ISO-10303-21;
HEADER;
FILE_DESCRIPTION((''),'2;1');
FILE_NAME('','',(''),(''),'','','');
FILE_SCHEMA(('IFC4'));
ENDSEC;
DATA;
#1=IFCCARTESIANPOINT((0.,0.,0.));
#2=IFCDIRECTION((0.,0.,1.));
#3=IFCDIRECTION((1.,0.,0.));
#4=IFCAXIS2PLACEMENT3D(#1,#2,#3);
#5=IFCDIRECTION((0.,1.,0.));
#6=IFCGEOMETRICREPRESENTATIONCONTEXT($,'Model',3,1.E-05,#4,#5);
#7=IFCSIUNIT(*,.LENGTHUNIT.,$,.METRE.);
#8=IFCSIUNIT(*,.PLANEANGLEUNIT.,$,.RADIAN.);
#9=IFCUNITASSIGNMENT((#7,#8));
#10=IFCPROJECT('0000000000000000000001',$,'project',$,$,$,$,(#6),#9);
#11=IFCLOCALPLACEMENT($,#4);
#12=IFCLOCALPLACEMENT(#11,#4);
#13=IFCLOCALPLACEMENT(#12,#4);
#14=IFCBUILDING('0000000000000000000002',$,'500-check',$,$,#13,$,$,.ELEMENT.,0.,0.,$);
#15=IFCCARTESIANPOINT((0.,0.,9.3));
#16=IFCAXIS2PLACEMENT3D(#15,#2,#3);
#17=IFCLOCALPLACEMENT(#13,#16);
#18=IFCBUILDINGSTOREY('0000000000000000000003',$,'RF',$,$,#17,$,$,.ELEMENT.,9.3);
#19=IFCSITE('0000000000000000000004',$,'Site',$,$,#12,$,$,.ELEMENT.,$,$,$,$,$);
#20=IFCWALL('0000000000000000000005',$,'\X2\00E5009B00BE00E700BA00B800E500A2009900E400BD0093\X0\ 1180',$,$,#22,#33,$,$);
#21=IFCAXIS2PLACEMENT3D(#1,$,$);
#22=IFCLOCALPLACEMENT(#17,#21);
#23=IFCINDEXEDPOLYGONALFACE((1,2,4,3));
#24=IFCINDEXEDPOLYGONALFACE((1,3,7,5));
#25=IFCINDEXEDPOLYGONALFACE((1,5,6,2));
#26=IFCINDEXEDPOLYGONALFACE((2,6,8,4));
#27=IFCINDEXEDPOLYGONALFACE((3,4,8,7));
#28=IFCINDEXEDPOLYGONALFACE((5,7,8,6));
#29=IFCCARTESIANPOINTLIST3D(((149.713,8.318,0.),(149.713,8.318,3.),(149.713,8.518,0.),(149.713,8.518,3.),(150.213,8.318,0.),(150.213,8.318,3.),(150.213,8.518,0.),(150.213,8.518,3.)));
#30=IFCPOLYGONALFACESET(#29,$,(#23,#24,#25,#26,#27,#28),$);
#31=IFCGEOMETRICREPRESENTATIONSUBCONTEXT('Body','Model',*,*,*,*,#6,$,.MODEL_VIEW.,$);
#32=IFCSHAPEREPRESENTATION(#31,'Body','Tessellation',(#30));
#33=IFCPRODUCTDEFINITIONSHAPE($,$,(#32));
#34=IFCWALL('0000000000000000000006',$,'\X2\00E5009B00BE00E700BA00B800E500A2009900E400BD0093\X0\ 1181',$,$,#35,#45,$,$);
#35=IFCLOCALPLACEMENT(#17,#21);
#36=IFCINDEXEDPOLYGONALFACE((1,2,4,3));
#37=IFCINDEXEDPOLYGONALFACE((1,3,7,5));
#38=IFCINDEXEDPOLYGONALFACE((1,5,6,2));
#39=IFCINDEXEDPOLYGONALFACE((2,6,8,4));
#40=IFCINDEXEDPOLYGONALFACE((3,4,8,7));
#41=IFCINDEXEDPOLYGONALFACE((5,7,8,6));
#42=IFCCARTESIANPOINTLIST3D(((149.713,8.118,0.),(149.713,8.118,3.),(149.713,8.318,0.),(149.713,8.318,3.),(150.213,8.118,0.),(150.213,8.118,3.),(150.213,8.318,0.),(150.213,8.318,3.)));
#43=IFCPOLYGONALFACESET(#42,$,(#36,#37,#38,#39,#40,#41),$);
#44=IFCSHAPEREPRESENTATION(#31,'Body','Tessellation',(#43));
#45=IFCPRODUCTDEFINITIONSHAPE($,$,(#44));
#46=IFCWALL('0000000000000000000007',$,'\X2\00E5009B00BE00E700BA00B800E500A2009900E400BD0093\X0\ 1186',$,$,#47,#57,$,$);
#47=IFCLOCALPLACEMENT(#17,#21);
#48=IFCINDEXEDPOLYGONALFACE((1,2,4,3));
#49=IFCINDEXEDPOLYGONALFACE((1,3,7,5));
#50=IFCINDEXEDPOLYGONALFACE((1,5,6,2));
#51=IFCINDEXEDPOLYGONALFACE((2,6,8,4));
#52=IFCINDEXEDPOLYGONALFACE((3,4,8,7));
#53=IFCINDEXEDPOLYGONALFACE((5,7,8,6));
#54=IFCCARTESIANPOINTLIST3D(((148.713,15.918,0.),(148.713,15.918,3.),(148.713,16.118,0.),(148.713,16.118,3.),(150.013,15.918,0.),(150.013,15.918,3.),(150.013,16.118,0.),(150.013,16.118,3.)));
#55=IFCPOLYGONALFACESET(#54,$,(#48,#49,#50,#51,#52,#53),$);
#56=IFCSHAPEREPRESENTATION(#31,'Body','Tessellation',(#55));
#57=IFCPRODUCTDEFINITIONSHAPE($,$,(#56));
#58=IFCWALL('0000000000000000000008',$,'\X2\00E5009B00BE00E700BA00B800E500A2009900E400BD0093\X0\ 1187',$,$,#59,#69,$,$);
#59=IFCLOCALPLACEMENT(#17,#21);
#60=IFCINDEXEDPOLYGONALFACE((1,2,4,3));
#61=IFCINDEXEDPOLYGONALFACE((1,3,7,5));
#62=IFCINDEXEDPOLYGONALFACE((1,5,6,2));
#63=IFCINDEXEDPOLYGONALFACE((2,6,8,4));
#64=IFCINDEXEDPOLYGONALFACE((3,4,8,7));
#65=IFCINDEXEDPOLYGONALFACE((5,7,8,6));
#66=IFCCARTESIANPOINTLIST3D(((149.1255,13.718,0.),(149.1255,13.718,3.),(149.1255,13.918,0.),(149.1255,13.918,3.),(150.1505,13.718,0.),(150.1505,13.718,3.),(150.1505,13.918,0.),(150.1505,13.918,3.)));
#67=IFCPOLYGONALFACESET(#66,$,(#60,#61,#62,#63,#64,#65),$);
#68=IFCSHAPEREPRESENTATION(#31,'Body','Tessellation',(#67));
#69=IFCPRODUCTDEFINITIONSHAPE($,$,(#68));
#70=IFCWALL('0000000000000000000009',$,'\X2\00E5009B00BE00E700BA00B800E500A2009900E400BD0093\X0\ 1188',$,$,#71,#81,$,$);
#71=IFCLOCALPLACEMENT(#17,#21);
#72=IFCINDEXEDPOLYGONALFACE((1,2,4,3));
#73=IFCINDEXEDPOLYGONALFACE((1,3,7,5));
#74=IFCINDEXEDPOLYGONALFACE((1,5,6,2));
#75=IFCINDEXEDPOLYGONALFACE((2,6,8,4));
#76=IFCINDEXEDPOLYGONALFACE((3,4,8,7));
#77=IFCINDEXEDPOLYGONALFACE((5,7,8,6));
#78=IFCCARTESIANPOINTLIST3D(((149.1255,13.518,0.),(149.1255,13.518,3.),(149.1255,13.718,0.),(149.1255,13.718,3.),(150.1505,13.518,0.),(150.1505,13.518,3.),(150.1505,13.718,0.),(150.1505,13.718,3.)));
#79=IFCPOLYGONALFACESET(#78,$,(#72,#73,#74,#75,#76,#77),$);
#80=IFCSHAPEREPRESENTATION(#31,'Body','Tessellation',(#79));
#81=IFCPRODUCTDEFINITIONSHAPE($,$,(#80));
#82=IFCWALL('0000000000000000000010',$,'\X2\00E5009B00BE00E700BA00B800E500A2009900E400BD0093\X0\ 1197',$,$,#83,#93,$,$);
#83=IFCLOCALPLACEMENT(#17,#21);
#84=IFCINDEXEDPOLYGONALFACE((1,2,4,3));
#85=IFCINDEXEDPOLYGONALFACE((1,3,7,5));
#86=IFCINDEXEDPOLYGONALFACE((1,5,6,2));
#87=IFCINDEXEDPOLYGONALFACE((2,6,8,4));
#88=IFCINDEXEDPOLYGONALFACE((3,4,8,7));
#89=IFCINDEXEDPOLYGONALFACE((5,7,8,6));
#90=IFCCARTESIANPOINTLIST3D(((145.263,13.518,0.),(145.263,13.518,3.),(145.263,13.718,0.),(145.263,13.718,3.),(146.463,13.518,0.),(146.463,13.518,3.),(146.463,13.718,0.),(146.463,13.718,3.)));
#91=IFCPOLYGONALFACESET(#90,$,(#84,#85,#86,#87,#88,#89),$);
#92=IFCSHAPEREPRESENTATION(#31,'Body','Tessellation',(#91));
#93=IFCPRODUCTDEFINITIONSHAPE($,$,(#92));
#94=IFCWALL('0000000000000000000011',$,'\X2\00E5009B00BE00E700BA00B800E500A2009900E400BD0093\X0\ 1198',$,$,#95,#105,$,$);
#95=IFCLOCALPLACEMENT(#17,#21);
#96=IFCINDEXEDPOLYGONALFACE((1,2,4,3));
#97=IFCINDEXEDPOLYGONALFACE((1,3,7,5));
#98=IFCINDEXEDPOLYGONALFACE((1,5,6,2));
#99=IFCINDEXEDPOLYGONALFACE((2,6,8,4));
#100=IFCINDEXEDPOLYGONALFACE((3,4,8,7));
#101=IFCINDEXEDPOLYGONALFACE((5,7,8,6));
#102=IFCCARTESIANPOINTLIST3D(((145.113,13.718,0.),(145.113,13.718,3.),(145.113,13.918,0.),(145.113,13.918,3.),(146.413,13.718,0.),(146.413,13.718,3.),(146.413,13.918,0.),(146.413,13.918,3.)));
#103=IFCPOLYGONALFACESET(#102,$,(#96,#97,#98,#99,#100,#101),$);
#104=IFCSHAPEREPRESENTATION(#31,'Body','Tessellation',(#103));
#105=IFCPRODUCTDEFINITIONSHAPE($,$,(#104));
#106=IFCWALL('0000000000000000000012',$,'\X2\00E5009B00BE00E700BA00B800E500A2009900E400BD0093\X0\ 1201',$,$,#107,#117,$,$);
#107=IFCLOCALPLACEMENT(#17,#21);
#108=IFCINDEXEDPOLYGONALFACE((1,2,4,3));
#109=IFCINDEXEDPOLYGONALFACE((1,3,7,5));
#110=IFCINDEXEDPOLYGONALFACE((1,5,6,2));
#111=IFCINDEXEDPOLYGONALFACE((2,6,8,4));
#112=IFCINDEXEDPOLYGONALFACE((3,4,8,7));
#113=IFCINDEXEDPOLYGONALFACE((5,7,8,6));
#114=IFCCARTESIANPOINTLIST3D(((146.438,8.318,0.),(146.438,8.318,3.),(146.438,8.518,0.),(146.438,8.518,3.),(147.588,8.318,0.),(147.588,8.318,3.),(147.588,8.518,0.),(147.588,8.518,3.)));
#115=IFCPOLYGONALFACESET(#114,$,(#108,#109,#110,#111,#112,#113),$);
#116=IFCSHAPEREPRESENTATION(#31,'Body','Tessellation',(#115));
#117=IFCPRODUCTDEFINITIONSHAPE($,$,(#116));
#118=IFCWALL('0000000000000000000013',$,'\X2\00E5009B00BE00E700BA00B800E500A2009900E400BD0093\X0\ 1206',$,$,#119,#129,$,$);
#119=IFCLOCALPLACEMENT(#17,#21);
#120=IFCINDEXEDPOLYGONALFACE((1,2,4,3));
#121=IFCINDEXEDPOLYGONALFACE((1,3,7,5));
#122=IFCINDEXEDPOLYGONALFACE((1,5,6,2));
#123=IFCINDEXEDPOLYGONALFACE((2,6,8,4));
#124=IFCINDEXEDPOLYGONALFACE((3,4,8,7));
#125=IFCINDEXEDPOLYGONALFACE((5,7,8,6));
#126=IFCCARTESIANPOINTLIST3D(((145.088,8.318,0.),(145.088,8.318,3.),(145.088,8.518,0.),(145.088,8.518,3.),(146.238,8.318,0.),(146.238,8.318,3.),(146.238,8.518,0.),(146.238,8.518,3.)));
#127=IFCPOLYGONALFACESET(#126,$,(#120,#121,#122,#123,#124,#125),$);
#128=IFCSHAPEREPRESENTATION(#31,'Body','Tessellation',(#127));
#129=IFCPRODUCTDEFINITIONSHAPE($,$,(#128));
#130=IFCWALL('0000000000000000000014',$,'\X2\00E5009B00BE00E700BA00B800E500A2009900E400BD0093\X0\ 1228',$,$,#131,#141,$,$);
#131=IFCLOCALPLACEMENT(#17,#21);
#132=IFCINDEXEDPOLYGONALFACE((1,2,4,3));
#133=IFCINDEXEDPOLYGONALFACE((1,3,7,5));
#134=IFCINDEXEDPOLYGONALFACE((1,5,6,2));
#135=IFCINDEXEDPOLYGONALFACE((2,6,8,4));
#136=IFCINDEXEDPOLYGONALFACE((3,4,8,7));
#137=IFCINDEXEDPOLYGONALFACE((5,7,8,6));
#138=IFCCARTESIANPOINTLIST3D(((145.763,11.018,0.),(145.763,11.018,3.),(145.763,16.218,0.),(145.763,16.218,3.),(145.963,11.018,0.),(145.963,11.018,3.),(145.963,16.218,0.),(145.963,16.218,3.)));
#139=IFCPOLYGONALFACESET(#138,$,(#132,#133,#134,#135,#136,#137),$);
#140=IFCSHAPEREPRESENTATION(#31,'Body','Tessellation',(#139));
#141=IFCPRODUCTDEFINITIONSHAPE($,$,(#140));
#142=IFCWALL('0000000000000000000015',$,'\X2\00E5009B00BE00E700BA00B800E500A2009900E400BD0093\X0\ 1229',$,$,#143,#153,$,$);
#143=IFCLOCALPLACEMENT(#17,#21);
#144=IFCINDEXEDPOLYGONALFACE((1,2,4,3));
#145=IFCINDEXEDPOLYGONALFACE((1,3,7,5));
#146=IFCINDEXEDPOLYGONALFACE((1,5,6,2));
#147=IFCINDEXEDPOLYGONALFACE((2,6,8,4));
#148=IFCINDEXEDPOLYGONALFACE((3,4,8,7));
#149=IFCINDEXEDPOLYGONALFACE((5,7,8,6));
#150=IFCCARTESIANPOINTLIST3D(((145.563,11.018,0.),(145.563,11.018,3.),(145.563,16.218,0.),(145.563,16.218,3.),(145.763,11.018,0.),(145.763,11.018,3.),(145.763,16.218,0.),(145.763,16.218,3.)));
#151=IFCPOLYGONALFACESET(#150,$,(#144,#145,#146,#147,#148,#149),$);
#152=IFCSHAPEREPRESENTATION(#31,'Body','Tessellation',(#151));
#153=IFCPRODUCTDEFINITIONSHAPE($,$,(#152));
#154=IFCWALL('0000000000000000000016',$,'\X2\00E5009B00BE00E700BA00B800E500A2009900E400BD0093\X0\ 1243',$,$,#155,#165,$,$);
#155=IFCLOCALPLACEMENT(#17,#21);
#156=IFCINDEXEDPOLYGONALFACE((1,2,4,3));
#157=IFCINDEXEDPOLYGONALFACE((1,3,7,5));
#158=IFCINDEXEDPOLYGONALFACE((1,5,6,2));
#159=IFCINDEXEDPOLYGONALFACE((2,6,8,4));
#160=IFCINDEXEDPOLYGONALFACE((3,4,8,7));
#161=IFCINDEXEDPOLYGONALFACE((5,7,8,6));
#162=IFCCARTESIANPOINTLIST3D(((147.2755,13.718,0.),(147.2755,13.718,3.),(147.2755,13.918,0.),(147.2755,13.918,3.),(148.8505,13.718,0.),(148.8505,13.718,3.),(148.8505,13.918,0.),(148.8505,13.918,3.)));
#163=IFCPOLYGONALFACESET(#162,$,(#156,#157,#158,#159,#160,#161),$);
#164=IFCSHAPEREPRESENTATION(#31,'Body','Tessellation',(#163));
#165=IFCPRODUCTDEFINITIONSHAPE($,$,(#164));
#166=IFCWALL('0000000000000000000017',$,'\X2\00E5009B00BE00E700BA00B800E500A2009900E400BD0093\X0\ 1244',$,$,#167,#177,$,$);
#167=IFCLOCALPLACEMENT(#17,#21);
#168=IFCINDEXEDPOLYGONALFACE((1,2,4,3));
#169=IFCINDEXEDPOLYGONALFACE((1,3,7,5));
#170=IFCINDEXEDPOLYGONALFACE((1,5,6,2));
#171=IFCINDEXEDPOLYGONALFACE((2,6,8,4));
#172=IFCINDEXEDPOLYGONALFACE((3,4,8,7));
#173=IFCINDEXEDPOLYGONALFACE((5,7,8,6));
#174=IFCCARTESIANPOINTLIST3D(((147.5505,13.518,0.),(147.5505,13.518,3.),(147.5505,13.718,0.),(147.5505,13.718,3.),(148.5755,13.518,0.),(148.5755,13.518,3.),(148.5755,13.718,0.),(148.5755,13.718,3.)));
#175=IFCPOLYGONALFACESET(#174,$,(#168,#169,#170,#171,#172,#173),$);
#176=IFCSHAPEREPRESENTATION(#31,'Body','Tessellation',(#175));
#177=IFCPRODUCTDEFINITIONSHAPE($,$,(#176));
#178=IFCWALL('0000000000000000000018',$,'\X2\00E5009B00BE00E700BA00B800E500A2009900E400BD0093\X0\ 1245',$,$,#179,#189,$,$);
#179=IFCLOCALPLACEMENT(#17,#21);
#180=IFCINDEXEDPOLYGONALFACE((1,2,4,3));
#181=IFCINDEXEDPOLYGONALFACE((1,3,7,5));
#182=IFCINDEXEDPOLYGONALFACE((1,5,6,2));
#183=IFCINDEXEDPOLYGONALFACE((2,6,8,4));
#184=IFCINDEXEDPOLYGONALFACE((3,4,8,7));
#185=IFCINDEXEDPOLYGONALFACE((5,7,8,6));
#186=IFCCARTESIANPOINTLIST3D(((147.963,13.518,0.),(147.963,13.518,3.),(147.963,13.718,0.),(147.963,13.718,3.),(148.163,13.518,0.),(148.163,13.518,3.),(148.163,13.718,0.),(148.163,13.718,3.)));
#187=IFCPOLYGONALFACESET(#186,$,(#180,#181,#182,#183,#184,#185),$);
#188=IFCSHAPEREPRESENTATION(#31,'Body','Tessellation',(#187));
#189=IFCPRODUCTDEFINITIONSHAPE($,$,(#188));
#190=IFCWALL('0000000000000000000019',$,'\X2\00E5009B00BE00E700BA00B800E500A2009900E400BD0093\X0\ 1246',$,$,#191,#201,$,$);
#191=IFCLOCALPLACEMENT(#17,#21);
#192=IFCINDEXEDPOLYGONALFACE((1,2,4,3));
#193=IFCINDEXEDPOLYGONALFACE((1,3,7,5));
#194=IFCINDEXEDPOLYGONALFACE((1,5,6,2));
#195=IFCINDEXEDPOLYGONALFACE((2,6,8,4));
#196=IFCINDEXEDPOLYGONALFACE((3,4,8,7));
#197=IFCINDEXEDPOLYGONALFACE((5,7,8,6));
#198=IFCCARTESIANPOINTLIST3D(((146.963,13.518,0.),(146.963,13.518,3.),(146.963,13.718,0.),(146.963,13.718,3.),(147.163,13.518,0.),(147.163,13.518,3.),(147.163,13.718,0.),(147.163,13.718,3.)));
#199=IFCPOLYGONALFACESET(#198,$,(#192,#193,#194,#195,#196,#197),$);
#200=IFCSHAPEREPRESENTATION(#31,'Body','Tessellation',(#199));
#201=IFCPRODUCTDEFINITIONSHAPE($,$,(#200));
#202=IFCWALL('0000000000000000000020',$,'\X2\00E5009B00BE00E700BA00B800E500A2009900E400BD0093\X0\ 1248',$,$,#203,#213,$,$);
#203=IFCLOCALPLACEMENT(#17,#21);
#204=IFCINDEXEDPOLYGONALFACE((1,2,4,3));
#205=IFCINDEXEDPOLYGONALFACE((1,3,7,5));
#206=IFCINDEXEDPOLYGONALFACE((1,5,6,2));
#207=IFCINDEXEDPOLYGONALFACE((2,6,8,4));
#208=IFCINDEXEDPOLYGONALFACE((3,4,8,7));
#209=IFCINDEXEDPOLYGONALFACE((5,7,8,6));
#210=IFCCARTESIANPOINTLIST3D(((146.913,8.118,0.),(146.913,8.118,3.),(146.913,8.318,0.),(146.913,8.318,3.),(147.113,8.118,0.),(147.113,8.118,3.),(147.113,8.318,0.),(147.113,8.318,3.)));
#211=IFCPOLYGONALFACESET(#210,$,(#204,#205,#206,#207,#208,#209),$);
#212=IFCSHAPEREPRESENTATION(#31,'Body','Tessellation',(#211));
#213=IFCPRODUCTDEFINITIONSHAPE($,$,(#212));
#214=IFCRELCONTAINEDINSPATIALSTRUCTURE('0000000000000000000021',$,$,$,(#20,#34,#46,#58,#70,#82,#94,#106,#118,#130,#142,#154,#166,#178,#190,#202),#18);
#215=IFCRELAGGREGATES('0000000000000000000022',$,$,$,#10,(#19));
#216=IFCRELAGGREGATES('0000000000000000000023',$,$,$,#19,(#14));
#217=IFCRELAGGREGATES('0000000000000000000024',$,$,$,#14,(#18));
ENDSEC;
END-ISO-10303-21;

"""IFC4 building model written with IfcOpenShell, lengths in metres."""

from ifc_helpers import new_model, si_unit, direction, frame, frame_2d, origin_with_axes, place, context, subcontext, project, spatial, rectangle, extrude, element, save


model = new_model("IFC4")

# Units and contexts
model_context = context("Model", 3, precision=1e-05, world=origin_with_axes(), true_north=direction((0.0, 1.0, 0.0)))
body_context = subcontext(model_context, "Body", "Model", "MODEL_VIEW")
ifc_project = project(units=[si_unit("LENGTHUNIT", "METRE"), si_unit("PLANEANGLEUNIT", "RADIAN")], contexts=[model_context])

# Site, building, storey
placement = place(None, origin_with_axes())
site_placement = place(placement, origin_with_axes())
site = spatial("IfcSite", under=ifc_project, at=site_placement, Name="Site", CompositionType="ELEMENT")
building_placement = place(site_placement, origin_with_axes())
building = spatial("IfcBuilding", under=site, at=building_placement, Name="500-check", CompositionType="ELEMENT", ElevationOfRefHeight=0.0, ElevationOfTerrain=0.0)
storey_placement = place(building_placement, frame((0.0, 0.0, 9.3), z_axis=(0.0, 0.0, 1.0), x_axis=(1.0, 0.0, 0.0)))
storey = spatial("IfcBuildingStorey", under=building, at=storey_placement, Name="RF", CompositionType="ELEMENT", Elevation=9.3)

# Walls
for number, where, z_axis, x_axis, name in (
    (1, (149.963, 8.418, 0.0), (0.0, 0.0, 1.0), (-1.0, 0.0, 0.0), "å\u009b¾çº¸å¢\u0099ä½\u0093 1180"),
    (2, (149.963, 8.218, 0.0), (0.0, 0.0, 1.0), (-1.0, 0.0, 0.0), "å\u009b¾çº¸å¢\u0099ä½\u0093 1181"),
):
    element("IfcWall", number, at=place(storey_placement, frame(where, z_axis=z_axis, x_axis=x_axis)), inside=storey, Name=name, context=body_context, shape_type="SweptSolid", body=[
        extrude(rectangle(XDim=0.5, YDim=0.2, at=frame_2d((0.0, 0.0), x_axis=(1.0, 0.0, 0.0))), frame((0.0, 0.0, 0.0), z_axis=(0.0, 0.0, 1.0)), (0.0, 0.0, 1.0), 3.0),
    ])
wall_1_placement = place(storey_placement, frame((149.363, 16.018, 0.0), z_axis=(0.0, 0.0, 1.0), x_axis=(1.0, 0.0, 0.0)))
element("IfcWall", 3, at=wall_1_placement, inside=storey, Name="å\u009b¾çº¸å¢\u0099ä½\u0093 1186", context=body_context, shape_type="SweptSolid", body=[
    extrude(rectangle(XDim=1.3, YDim=0.2, at=frame_2d((0.0, 0.0), x_axis=(1.0, 0.0, 0.0))), frame((0.0, 0.0, 0.0), z_axis=(0.0, 0.0, 1.0)), (0.0, 0.0, 1.0), 3.0),
])
for number, where, z_axis, x_axis, name in (
    (4, (149.638, 13.818, 0.0), (0.0, 0.0, 1.0), (1.0, 0.0, 0.0), "å\u009b¾çº¸å¢\u0099ä½\u0093 1187"),
    (5, (149.638, 13.618, 0.0), (0.0, 0.0, 1.0), (1.0, 0.0, 0.0), "å\u009b¾çº¸å¢\u0099ä½\u0093 1188"),
):
    element("IfcWall", number, at=place(storey_placement, frame(where, z_axis=z_axis, x_axis=x_axis)), inside=storey, Name=name, context=body_context, shape_type="SweptSolid", body=[
        extrude(rectangle(XDim=1.025, YDim=0.2, at=frame_2d((0.0, 0.0), x_axis=(1.0, 0.0, 0.0))), frame((0.0, 0.0, 0.0), z_axis=(0.0, 0.0, 1.0)), (0.0, 0.0, 1.0), 3.0),
    ])
wall_2_placement = place(storey_placement, frame((145.863, 13.618, 0.0), z_axis=(0.0, 0.0, 1.0), x_axis=(1.0, 0.0, 0.0)))
element("IfcWall", 6, at=wall_2_placement, inside=storey, Name="å\u009b¾çº¸å¢\u0099ä½\u0093 1197", context=body_context, shape_type="SweptSolid", body=[
    extrude(rectangle(XDim=1.2, YDim=0.2, at=frame_2d((0.0, 0.0), x_axis=(1.0, 0.0, 0.0))), frame((0.0, 0.0, 0.0), z_axis=(0.0, 0.0, 1.0)), (0.0, 0.0, 1.0), 3.0),
])
wall_3_placement = place(storey_placement, frame((145.763, 13.818, 0.0), z_axis=(0.0, 0.0, 1.0), x_axis=(1.0, 0.0, 0.0)))
element("IfcWall", 7, at=wall_3_placement, inside=storey, Name="å\u009b¾çº¸å¢\u0099ä½\u0093 1198", context=body_context, shape_type="SweptSolid", body=[
    extrude(rectangle(XDim=1.3, YDim=0.2, at=frame_2d((0.0, 0.0), x_axis=(1.0, 0.0, 0.0))), frame((0.0, 0.0, 0.0), z_axis=(0.0, 0.0, 1.0)), (0.0, 0.0, 1.0), 3.0),
])
for number, where, z_axis, x_axis, name in (
    (8, (147.013, 8.418, 0.0), (0.0, 0.0, 1.0), (-1.0, 0.0, 0.0), "å\u009b¾çº¸å¢\u0099ä½\u0093 1201"),
    (9, (145.663, 8.418, 0.0), (0.0, 0.0, 1.0), (-1.0, 0.0, 0.0), "å\u009b¾çº¸å¢\u0099ä½\u0093 1206"),
):
    element("IfcWall", number, at=place(storey_placement, frame(where, z_axis=z_axis, x_axis=x_axis)), inside=storey, Name=name, context=body_context, shape_type="SweptSolid", body=[
        extrude(rectangle(XDim=1.15, YDim=0.2, at=frame_2d((0.0, 0.0), x_axis=(1.0, 0.0, 0.0))), frame((0.0, 0.0, 0.0), z_axis=(0.0, 0.0, 1.0)), (0.0, 0.0, 1.0), 3.0),
    ])
for number, where, z_axis, x_axis, name in (
    (10, (145.863, 13.618, 0.0), (0.0, 0.0, 1.0), (0.0, -1.0, 0.0), "å\u009b¾çº¸å¢\u0099ä½\u0093 1228"),
    (11, (145.663, 13.618, 0.0), (0.0, 0.0, 1.0), (0.0, -1.0, 0.0), "å\u009b¾çº¸å¢\u0099ä½\u0093 1229"),
):
    element("IfcWall", number, at=place(storey_placement, frame(where, z_axis=z_axis, x_axis=x_axis)), inside=storey, Name=name, context=body_context, shape_type="SweptSolid", body=[
        extrude(rectangle(XDim=5.2, YDim=0.2, at=frame_2d((0.0, 0.0), x_axis=(1.0, 0.0, 0.0))), frame((0.0, 0.0, 0.0), z_axis=(0.0, 0.0, 1.0)), (0.0, 0.0, 1.0), 3.0),
    ])
wall_4_placement = place(storey_placement, frame((148.063, 13.818, 0.0), z_axis=(0.0, 0.0, 1.0), x_axis=(1.0, 0.0, 0.0)))
element("IfcWall", 12, at=wall_4_placement, inside=storey, Name="å\u009b¾çº¸å¢\u0099ä½\u0093 1243", context=body_context, shape_type="SweptSolid", body=[
    extrude(rectangle(XDim=1.575, YDim=0.2, at=frame_2d((0.0, 0.0), x_axis=(1.0, 0.0, 0.0))), frame((0.0, 0.0, 0.0), z_axis=(0.0, 0.0, 1.0)), (0.0, 0.0, 1.0), 3.0),
])
wall_5_placement = place(storey_placement, frame((148.063, 13.618, 0.0), z_axis=(0.0, 0.0, 1.0), x_axis=(1.0, 0.0, 0.0)))
element("IfcWall", 13, at=wall_5_placement, inside=storey, Name="å\u009b¾çº¸å¢\u0099ä½\u0093 1244", context=body_context, shape_type="SweptSolid", body=[
    extrude(rectangle(XDim=1.025, YDim=0.2, at=frame_2d((0.0, 0.0), x_axis=(1.0, 0.0, 0.0))), frame((0.0, 0.0, 0.0), z_axis=(0.0, 0.0, 1.0)), (0.0, 0.0, 1.0), 3.0),
])
for number, where, z_axis, x_axis, name in (
    (14, (148.063, 13.618, 0.0), (0.0, 0.0, 1.0), (0.0, 1.0, 0.0), "å\u009b¾çº¸å¢\u0099ä½\u0093 1245"),
    (15, (147.063, 13.618, 0.0), (0.0, 0.0, 1.0), (0.0, 1.0, 0.0), "å\u009b¾çº¸å¢\u0099ä½\u0093 1246"),
    (16, (147.013, 8.218, 0.0), (0.0, 0.0, 1.0), (0.0, 1.0, 0.0), "å\u009b¾çº¸å¢\u0099ä½\u0093 1248"),
):
    element("IfcWall", number, at=place(storey_placement, frame(where, z_axis=z_axis, x_axis=x_axis)), inside=storey, Name=name, context=body_context, shape_type="SweptSolid", body=[
        extrude(rectangle(XDim=0.2, YDim=0.2, at=frame_2d((0.0, 0.0), x_axis=(1.0, 0.0, 0.0))), frame((0.0, 0.0, 0.0), z_axis=(0.0, 0.0, 1.0)), (0.0, 0.0, 1.0), 3.0),
    ])

save(model, "model.ifc")
